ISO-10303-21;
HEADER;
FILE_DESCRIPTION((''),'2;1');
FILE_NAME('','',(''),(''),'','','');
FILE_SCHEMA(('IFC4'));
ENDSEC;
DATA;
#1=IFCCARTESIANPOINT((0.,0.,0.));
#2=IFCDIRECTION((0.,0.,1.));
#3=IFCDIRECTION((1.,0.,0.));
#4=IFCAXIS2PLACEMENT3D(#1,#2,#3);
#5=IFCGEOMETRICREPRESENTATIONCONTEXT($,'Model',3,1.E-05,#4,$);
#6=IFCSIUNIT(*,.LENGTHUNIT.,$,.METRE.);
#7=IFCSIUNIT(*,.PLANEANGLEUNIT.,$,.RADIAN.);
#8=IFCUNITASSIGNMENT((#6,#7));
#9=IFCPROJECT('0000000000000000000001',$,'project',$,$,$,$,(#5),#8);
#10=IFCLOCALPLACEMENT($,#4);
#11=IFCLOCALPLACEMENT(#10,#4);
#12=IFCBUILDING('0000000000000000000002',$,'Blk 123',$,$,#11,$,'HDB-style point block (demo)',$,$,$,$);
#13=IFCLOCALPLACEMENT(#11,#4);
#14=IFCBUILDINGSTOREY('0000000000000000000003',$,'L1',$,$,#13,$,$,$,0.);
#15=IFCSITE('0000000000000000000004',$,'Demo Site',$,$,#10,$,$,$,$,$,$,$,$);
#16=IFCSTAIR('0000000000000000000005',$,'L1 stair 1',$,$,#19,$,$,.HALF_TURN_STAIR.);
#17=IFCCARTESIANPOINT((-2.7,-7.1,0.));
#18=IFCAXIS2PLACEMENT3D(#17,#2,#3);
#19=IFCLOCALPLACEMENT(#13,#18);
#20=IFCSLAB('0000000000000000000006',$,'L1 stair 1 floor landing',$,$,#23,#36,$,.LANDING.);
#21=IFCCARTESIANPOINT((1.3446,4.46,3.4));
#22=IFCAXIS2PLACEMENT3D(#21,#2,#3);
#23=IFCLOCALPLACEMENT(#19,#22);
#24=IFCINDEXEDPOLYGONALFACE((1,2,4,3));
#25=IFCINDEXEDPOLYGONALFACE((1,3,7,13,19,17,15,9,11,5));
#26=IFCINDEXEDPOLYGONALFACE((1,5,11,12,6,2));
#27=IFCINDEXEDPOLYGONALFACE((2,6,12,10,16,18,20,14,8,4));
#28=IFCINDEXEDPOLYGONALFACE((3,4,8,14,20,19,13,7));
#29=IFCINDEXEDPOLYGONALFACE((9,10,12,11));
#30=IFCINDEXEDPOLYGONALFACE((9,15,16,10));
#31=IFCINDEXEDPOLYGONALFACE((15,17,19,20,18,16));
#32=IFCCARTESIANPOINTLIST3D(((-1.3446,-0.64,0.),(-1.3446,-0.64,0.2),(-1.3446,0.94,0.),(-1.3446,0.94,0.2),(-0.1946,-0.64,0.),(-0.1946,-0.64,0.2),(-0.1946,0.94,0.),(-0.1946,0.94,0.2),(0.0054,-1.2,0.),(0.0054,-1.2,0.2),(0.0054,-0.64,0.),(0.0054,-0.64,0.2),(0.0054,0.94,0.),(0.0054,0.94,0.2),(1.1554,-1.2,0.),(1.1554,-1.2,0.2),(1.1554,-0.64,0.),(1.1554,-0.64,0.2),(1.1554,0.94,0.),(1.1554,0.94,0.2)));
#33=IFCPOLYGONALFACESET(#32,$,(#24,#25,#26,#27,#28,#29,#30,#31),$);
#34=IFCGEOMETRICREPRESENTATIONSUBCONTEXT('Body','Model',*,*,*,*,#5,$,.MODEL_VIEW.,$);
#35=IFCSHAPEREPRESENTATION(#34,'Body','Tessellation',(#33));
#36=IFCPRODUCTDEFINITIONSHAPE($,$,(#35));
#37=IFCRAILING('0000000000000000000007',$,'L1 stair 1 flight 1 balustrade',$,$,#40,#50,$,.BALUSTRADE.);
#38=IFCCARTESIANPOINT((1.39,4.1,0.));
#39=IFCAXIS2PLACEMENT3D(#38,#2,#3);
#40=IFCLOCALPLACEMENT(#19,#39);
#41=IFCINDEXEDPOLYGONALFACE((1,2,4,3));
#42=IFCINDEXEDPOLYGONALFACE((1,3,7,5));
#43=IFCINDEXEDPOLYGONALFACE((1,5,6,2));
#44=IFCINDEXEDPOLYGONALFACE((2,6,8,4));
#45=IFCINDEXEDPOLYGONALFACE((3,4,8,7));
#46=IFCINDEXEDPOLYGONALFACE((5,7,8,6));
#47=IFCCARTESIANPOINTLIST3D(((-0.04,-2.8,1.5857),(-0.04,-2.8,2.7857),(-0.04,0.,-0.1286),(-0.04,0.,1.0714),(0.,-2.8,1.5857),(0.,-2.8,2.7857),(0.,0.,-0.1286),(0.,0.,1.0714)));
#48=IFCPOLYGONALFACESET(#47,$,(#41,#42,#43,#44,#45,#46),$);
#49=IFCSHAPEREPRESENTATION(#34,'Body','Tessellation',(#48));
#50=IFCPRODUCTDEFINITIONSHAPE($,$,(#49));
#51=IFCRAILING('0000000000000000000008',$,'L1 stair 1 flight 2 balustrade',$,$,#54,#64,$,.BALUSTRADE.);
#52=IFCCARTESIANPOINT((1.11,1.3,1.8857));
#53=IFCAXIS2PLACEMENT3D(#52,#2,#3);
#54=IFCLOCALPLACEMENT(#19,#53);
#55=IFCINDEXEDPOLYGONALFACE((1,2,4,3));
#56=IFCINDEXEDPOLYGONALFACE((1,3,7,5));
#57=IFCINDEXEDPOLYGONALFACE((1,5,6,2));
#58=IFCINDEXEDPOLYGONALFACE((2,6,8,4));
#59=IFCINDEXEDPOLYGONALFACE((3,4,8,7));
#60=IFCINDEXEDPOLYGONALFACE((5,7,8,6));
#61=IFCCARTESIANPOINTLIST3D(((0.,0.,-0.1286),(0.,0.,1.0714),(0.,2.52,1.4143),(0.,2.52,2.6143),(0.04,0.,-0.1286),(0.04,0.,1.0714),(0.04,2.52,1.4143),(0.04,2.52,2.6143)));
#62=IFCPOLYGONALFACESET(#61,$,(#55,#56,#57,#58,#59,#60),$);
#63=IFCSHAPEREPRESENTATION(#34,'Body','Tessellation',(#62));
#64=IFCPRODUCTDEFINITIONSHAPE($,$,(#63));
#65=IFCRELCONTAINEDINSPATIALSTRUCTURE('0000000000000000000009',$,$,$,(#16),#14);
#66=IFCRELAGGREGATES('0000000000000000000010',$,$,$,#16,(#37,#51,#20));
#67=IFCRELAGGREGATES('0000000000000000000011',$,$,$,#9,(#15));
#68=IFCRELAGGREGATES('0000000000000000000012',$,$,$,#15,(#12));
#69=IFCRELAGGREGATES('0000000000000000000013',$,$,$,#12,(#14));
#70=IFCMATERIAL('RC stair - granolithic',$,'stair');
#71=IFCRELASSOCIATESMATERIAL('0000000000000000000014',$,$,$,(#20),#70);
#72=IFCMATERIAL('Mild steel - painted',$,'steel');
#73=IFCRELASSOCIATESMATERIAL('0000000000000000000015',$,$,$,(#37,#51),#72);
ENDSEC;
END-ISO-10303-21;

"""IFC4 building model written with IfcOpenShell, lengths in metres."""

from ifc_helpers import new_model, si_unit, frame, origin, origin_with_axes, place, context, subcontext, project, spatial, polyline, outline, extrude, material, element, aggregate, save


model = new_model("IFC4")

# Units and contexts
model_context = context("Model", 3, precision=1e-05, world=origin_with_axes())
body_context = subcontext(model_context, "Body", "Model", "MODEL_VIEW")
ifc_project = project(units=[si_unit("LENGTHUNIT", "METRE"), si_unit("PLANEANGLEUNIT", "RADIAN")], contexts=[model_context])

# Site, building, storey
site_placement = place(None, origin_with_axes())
site = spatial("IfcSite", under=ifc_project, at=site_placement, Name="Demo Site")
building_placement = place(site_placement, origin_with_axes())
building = spatial("IfcBuilding", under=site, at=building_placement, Name="Blk 123", LongName="HDB-style point block (demo)")
storey_placement = place(building_placement, origin_with_axes())
storey = spatial("IfcBuildingStorey", under=building, at=storey_placement, Name="L1", Elevation=0.0)

# Stair, slab
stair_placement = place(storey_placement, frame((-2.7, -7.1, 0.0), z_axis=(0.0, 0.0, 1.0), x_axis=(1.0, 0.0, 0.0)))
stair = element("IfcStair", 1, at=stair_placement, inside=storey, Name="L1 stair 1", PredefinedType="HALF_TURN_STAIR")
ifc_material_1 = material(Name="RC stair - granolithic", Category="stair")
slab_1_placement = place(stair_placement, frame((1.3446, 4.46, 3.4), z_axis=(0.0, 0.0, 1.0), x_axis=(1.0, 0.0, 0.0)))
slab_1 = element("IfcSlab", 2, at=slab_1_placement, material=ifc_material_1, Name="L1 stair 1 floor landing", PredefinedType="LANDING", context=body_context, shape_type="SweptSolid", body=[
    extrude(outline(polyline([(-0.1946, 0.94), (-1.3446, 0.94), (-1.3446, -0.64), (-0.1946, -0.64), (0.0054, -0.64), (0.0054, -1.2), (1.1554, -1.2), (1.1554, -0.64), (1.1554, 0.94), (0.0054, 0.94), (-0.1946, 0.94)])), origin(), (0.0, 0.0, 1.0), 0.2),
])

# Shared definitions
ifc_material_2 = material(Name="Mild steel - painted", Category="steel")

# Railings
railing_1_placement = place(stair_placement, frame((1.39, 4.1, 0.0), z_axis=(0.0, 0.0, 1.0), x_axis=(1.0, 0.0, 0.0)))
railing_1 = element("IfcRailing", 3, at=railing_1_placement, material=ifc_material_2, Name="L1 stair 1 flight 1 balustrade", PredefinedType="BALUSTRADE", context=body_context, shape_type="SweptSolid", body=[
    extrude(outline(polyline([(0.0, -0.1286), (2.8, 1.5857), (2.8, 2.7857), (0.0, 1.0714), (0.0, -0.1286)])), frame((0.0, 0.0, 0.0), z_axis=(-1.0, 0.0, 0.0), x_axis=(0.0, -1.0, 0.0)), (0.0, 0.0, 1.0), 0.04),
])
railing_2_placement = place(stair_placement, frame((1.11, 1.3, 1.8857), z_axis=(0.0, 0.0, 1.0), x_axis=(1.0, 0.0, 0.0)))
railing_2 = element("IfcRailing", 4, at=railing_2_placement, material=ifc_material_2, Name="L1 stair 1 flight 2 balustrade", PredefinedType="BALUSTRADE", context=body_context, shape_type="SweptSolid", body=[
    extrude(outline(polyline([(0.0, -0.1286), (2.52, 1.4143), (2.52, 2.6143), (0.0, 1.0714), (0.0, -0.1286)])), frame((0.0, 0.0, 0.0), z_axis=(1.0, 0.0, 0.0), x_axis=(0.0, 1.0, 0.0)), (0.0, 0.0, 1.0), 0.04),
])
aggregate(stair, [railing_1, railing_2, slab_1])

save(model, "model.ifc")
